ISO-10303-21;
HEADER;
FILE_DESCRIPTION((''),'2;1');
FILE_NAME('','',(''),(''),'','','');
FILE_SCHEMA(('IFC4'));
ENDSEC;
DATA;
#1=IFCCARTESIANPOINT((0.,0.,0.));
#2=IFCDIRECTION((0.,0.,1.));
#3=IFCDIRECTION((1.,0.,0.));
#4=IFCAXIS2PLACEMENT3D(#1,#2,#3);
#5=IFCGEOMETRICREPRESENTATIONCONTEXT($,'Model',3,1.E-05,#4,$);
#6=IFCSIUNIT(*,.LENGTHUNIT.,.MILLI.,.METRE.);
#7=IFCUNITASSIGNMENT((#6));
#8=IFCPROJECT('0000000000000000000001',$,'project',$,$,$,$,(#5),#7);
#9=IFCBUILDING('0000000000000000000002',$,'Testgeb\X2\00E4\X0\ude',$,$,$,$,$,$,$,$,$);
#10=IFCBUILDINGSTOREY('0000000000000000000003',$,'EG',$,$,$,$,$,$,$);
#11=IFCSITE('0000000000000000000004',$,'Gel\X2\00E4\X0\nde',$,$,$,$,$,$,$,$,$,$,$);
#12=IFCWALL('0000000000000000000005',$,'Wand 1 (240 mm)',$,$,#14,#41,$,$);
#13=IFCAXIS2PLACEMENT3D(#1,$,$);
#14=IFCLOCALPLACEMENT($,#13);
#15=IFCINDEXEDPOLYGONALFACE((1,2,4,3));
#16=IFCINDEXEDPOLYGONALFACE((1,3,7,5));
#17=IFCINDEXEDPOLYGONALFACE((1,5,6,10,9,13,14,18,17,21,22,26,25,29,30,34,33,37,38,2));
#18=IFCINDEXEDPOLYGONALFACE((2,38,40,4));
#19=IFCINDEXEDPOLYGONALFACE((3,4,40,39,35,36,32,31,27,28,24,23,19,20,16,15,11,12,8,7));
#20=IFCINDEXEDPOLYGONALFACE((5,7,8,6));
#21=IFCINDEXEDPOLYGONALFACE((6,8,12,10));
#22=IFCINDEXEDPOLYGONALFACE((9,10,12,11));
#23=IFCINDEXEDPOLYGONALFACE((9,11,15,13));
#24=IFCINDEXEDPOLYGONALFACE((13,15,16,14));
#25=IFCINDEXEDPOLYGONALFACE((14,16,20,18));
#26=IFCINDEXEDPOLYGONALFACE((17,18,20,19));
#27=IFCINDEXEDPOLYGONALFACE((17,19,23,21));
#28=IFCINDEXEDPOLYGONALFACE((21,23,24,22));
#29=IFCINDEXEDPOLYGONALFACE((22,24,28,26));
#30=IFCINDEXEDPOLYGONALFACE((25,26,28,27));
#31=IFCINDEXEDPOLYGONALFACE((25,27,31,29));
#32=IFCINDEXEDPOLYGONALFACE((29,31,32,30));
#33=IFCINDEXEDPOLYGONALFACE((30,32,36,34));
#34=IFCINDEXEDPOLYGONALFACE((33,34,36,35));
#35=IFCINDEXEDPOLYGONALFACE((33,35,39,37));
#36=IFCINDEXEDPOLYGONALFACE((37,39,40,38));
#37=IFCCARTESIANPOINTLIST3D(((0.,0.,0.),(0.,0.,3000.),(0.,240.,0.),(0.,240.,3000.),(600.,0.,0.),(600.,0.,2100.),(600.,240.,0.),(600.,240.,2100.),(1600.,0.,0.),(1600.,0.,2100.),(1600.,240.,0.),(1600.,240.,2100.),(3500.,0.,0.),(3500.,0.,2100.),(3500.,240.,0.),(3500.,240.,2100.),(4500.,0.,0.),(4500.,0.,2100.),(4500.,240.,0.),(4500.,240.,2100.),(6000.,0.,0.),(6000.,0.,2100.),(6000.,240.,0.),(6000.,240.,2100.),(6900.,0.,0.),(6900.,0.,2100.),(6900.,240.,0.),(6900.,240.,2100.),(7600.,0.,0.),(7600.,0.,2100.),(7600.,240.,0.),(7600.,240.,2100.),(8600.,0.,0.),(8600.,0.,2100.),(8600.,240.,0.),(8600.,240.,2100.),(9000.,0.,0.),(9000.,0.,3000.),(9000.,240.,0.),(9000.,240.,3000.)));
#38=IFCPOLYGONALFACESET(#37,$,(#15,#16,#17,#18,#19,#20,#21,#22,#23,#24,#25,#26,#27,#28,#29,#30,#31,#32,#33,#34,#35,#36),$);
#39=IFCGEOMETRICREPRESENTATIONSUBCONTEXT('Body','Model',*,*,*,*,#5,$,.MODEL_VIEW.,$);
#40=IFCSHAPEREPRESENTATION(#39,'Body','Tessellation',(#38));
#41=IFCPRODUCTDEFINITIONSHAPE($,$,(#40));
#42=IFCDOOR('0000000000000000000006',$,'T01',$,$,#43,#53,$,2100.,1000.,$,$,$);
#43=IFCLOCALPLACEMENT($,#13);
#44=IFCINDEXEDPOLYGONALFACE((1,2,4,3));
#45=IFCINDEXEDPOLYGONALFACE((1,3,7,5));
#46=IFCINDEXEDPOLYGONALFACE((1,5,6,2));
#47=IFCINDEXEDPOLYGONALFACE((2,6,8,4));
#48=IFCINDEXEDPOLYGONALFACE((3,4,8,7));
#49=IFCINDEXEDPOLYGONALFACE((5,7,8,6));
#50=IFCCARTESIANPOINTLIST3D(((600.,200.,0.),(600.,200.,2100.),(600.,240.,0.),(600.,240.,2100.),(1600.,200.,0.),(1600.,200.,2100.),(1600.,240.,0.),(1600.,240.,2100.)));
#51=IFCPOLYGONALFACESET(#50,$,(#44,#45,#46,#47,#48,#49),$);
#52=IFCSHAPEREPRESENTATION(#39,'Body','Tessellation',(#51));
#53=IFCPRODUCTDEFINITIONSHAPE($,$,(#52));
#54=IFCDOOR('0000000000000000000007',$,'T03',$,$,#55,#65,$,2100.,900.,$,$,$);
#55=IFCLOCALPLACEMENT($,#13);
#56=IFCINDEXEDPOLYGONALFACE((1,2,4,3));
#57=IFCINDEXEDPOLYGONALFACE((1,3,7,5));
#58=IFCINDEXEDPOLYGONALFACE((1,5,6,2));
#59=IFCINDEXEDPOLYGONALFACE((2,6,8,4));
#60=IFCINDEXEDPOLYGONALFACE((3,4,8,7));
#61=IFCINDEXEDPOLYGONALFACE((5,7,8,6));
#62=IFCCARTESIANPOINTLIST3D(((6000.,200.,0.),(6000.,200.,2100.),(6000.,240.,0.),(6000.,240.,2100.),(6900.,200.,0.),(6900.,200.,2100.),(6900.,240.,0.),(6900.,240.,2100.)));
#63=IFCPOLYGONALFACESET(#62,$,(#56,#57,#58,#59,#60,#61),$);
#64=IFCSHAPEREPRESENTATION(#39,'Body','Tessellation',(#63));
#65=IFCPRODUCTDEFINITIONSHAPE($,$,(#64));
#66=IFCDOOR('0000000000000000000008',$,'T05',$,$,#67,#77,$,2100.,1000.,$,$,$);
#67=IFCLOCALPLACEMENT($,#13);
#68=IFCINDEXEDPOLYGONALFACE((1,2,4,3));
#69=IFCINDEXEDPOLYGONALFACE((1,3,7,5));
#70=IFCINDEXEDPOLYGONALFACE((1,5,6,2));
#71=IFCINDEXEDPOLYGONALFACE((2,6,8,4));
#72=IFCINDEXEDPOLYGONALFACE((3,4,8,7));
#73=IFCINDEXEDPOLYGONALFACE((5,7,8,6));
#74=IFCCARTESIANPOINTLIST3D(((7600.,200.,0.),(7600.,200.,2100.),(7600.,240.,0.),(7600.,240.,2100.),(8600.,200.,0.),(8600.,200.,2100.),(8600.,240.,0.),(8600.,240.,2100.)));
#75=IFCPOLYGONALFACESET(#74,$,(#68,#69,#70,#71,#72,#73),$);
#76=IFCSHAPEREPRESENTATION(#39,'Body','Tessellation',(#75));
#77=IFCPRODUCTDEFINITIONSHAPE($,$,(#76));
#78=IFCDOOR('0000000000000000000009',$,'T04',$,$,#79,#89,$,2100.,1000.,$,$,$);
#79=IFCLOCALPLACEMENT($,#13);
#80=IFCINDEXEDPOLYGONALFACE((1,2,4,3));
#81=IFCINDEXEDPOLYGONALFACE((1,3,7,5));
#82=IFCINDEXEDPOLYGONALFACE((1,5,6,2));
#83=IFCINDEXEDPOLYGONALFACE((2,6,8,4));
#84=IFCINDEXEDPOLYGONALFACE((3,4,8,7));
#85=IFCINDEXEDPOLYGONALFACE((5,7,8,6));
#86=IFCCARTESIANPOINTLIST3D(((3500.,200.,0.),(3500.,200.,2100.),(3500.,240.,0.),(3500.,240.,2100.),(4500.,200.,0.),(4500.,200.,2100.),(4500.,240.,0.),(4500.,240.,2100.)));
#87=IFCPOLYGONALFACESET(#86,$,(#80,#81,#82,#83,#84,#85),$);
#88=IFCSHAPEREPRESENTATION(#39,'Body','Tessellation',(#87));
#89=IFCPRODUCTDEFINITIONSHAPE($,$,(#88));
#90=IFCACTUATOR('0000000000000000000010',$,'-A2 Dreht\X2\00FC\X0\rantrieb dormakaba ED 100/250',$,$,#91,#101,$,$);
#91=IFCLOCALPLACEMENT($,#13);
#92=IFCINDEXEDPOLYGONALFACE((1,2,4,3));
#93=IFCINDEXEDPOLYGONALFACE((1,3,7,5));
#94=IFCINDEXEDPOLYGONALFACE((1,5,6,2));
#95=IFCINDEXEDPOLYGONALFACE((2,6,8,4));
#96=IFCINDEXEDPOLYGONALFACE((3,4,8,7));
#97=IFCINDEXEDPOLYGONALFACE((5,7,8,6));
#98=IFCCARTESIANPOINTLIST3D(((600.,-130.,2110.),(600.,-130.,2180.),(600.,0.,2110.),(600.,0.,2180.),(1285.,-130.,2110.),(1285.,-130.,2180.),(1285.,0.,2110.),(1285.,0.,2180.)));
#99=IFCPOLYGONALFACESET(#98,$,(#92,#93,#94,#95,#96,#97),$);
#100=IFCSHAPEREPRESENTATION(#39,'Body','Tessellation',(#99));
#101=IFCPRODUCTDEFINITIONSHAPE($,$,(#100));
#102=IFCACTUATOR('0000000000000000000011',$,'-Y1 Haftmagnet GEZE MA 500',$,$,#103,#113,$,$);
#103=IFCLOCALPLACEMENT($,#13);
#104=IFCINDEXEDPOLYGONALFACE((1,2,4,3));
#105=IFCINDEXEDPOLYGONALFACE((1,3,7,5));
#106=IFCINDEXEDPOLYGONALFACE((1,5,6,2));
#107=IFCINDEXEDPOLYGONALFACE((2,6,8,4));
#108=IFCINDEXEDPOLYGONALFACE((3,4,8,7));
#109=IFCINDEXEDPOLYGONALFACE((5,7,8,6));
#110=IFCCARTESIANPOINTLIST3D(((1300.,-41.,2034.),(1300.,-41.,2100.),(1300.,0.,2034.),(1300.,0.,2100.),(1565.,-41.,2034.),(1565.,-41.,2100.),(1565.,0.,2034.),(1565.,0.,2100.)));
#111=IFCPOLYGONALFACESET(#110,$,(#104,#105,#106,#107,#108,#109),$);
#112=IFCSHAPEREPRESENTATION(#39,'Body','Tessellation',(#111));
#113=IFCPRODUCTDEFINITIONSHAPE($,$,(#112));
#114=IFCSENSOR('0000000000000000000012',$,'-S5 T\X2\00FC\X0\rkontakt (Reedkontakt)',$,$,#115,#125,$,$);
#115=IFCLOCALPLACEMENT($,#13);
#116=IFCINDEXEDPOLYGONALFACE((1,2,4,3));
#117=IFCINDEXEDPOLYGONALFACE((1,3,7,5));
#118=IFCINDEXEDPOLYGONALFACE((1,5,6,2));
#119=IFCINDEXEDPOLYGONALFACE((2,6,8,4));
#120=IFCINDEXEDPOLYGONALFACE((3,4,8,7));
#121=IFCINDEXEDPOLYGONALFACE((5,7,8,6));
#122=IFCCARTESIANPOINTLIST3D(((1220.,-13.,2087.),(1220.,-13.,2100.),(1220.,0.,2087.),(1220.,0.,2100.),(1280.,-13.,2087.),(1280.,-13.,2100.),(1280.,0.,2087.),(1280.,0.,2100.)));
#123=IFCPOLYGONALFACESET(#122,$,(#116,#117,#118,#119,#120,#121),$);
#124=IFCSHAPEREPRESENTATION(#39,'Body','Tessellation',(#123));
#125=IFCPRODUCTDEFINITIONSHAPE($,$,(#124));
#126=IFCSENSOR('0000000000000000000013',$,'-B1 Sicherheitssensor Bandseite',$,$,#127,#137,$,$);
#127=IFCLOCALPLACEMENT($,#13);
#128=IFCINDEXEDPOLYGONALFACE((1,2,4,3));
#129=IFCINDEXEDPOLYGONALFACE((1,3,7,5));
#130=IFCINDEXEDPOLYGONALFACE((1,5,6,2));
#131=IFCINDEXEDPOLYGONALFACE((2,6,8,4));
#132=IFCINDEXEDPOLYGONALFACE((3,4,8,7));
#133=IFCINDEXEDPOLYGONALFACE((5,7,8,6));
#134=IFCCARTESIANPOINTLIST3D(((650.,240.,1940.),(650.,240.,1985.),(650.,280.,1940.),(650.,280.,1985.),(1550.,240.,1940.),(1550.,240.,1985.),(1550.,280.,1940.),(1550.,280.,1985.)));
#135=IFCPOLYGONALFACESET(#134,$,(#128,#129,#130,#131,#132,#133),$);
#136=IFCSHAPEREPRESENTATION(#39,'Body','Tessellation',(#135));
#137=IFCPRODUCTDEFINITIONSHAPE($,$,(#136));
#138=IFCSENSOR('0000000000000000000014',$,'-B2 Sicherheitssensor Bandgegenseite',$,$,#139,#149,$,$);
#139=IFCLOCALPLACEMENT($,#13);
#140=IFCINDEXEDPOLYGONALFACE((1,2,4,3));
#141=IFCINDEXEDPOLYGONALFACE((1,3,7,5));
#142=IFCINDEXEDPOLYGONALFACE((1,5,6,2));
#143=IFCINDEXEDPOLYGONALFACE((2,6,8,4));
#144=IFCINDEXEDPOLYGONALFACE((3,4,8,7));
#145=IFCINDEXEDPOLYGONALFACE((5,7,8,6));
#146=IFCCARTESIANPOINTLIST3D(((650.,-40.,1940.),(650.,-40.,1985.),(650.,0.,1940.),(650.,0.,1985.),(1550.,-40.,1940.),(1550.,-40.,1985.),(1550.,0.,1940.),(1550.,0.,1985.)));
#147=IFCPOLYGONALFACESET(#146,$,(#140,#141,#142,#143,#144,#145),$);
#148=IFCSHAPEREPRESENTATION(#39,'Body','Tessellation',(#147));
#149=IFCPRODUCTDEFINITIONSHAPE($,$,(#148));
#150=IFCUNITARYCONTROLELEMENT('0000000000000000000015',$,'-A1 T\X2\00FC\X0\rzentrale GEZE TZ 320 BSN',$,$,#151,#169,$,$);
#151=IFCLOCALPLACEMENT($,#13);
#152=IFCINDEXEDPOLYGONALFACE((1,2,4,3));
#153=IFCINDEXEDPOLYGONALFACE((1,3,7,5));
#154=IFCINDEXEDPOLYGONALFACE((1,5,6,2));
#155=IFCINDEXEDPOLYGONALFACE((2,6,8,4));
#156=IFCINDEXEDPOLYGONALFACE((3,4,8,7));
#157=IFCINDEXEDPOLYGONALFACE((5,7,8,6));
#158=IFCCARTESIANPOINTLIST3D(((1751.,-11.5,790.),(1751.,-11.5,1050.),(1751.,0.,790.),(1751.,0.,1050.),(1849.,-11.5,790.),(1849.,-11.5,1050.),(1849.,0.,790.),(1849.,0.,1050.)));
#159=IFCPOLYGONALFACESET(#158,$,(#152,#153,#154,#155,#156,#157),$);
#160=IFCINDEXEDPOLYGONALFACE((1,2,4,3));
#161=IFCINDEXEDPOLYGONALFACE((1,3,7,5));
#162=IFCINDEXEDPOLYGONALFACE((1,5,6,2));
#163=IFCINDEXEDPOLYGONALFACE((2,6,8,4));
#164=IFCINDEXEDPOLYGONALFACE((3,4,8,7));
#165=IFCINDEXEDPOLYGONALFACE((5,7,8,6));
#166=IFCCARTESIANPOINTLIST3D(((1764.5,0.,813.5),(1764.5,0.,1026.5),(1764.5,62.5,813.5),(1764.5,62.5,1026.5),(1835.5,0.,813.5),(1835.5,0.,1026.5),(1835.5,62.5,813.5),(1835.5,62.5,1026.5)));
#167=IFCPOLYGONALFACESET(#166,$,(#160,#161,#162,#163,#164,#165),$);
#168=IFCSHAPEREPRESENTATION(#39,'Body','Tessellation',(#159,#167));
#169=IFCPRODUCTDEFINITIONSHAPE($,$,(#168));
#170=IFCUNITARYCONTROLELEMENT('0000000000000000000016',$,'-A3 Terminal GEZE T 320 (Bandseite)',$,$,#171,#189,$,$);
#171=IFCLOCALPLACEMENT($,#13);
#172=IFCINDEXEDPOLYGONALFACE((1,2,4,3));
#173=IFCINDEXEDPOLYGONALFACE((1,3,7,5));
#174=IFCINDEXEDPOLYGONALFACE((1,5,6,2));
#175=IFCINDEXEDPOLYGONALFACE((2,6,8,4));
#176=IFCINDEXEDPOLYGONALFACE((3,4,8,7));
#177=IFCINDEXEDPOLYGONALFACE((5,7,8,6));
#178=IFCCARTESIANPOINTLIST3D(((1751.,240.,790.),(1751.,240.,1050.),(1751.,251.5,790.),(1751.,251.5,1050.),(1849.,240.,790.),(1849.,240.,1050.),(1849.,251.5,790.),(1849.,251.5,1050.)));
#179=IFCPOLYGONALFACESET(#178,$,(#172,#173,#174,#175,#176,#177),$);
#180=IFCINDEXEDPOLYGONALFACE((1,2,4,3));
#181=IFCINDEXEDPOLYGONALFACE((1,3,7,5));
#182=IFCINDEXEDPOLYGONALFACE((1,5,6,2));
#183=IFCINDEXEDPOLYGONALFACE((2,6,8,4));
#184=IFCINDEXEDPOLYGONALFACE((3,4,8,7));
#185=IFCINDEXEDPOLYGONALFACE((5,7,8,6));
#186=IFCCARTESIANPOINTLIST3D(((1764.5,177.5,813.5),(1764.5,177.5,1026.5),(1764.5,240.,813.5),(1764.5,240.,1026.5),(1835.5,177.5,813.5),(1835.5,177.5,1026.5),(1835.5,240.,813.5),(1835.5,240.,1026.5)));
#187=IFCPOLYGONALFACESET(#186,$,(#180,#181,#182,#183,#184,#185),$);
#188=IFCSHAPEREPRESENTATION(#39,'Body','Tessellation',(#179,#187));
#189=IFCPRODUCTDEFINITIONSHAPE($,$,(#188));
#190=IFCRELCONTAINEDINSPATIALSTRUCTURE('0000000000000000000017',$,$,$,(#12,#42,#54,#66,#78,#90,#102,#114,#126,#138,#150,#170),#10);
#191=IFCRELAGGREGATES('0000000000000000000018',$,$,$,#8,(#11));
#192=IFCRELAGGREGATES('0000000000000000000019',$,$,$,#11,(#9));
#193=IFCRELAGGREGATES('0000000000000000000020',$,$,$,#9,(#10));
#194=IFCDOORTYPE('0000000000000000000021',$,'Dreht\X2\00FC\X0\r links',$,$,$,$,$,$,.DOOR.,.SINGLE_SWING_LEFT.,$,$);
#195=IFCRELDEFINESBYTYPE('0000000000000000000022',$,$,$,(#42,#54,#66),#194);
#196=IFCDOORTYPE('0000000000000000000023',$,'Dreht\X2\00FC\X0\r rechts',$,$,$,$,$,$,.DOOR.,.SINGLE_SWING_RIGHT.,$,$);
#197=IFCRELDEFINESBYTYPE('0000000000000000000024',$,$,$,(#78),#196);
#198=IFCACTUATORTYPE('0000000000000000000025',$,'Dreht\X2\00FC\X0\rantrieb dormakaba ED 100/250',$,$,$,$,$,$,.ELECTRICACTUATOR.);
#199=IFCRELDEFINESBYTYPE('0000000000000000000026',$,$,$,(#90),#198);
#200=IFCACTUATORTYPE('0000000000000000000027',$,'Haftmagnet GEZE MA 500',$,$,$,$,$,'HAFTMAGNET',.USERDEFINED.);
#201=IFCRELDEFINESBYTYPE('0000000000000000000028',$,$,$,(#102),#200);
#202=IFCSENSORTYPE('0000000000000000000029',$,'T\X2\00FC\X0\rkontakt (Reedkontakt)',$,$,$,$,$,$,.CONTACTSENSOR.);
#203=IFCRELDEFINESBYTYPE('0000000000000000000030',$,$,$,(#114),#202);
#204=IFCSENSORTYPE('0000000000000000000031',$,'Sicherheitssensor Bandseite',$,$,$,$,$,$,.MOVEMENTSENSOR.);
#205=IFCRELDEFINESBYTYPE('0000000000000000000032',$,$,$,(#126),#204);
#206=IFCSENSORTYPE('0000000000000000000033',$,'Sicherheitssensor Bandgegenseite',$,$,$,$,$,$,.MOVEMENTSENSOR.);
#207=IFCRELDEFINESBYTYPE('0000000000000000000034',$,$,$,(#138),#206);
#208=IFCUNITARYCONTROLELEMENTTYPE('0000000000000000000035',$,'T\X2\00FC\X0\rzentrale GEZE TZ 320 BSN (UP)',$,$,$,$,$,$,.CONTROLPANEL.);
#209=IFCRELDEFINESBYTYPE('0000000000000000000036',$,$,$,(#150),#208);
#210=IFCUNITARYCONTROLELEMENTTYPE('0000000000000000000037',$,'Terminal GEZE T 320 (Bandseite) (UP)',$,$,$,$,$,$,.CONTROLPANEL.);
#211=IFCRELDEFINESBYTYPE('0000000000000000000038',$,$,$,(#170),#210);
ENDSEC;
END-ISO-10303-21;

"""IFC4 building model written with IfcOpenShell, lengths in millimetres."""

from ifc_helpers import new_model, si_unit, frame, frame_2d, origin_with_axes, place, context, subcontext, project, spatial, rectangle, extrude, type_object, element, fill, save


model = new_model("IFC4")

# Units and contexts
model_context = context("Model", 3, precision=1e-05, world=origin_with_axes())
body_context = subcontext(model_context, "Body", "Model", "MODEL_VIEW")
ifc_project = project(units=[si_unit("LENGTHUNIT", "METRE", prefix="MILLI")], contexts=[model_context])

# Site, building, storey
site = spatial("IfcSite", under=ifc_project, Name="Gelände")
building = spatial("IfcBuilding", under=site, Name="Testgebäude")
storey = spatial("IfcBuildingStorey", under=building, Name="EG")

# Wall, openings, doors
wall_placement = place(None, origin_with_axes())
wall = element("IfcWall", 1, at=wall_placement, inside=storey, Name="Wand 1 (240 mm)", context=body_context, shape_type="SweptSolid", body=[
    extrude(rectangle(XDim=9000.0, YDim=240.0, at=frame_2d((4500.0, 120.0))), None, (0.0, 0.0, 1.0), 3000.0),
])
opening_1_placement = place(None, frame((600.0, 0.0, 0.0), z_axis=(0.0, 0.0, 1.0), x_axis=(1.0, 0.0, 0.0)))
opening_1 = element("IfcOpeningElement", 2, at=opening_1_placement, cuts=wall, context=body_context, shape_type="SweptSolid", body=[
    extrude(rectangle(XDim=1000.0, YDim=240.0, at=frame_2d((500.0, 120.0))), None, (0.0, 0.0, 1.0), 2100.0),
])
opening_2_placement = place(None, frame((3500.0, 0.0, 0.0), z_axis=(0.0, 0.0, 1.0), x_axis=(1.0, 0.0, 0.0)))
opening_2 = element("IfcOpeningElement", 3, at=opening_2_placement, cuts=wall, context=body_context, shape_type="SweptSolid", body=[
    extrude(rectangle(XDim=1000.0, YDim=240.0, at=frame_2d((500.0, 120.0))), None, (0.0, 0.0, 1.0), 2100.0),
])
opening_3_placement = place(None, frame((6000.0, 0.0, 0.0), z_axis=(0.0, 0.0, 1.0), x_axis=(1.0, 0.0, 0.0)))
opening_3 = element("IfcOpeningElement", 4, at=opening_3_placement, cuts=wall, context=body_context, shape_type="SweptSolid", body=[
    extrude(rectangle(XDim=900.0, YDim=240.0, at=frame_2d((450.0, 120.0))), None, (0.0, 0.0, 1.0), 2100.0),
])
opening_4_placement = place(None, frame((7600.0, 0.0, 0.0), z_axis=(0.0, 0.0, 1.0), x_axis=(1.0, 0.0, 0.0)))
opening_4 = element("IfcOpeningElement", 5, at=opening_4_placement, cuts=wall, context=body_context, shape_type="SweptSolid", body=[
    extrude(rectangle(XDim=1000.0, YDim=240.0, at=frame_2d((500.0, 120.0))), None, (0.0, 0.0, 1.0), 2100.0),
])
door_type_1 = type_object("IfcDoorType", Name="Drehtür links", OperationType="SINGLE_SWING_LEFT", PredefinedType="DOOR")
door_1_placement = place(opening_1_placement, origin_with_axes())
door_1 = element("IfcDoor", 6, at=door_1_placement, inside=storey, type_object=door_type_1, Name="T01", OverallHeight=2100.0, OverallWidth=1000.0, context=body_context, shape_type="SweptSolid", body=[
    extrude(rectangle(XDim=1000.0, YDim=40.0, at=frame_2d((500.0, 20.0))), frame((0.0, 200.0, 0.0)), (0.0, 0.0, 1.0), 2100.0),
])
fill(opening_1, door_1)
door_2_placement = place(opening_3_placement, origin_with_axes())
door_2 = element("IfcDoor", 7, at=door_2_placement, inside=storey, type_object=door_type_1, Name="T03", OverallHeight=2100.0, OverallWidth=900.0, context=body_context, shape_type="SweptSolid", body=[
    extrude(rectangle(XDim=900.0, YDim=40.0, at=frame_2d((450.0, 20.0))), frame((0.0, 200.0, 0.0)), (0.0, 0.0, 1.0), 2100.0),
])
fill(opening_3, door_2)
door_3_placement = place(opening_4_placement, origin_with_axes())
door_3 = element("IfcDoor", 8, at=door_3_placement, inside=storey, type_object=door_type_1, Name="T05", OverallHeight=2100.0, OverallWidth=1000.0, context=body_context, shape_type="SweptSolid", body=[
    extrude(rectangle(XDim=1000.0, YDim=40.0, at=frame_2d((500.0, 20.0))), frame((0.0, 200.0, 0.0)), (0.0, 0.0, 1.0), 2100.0),
])
fill(opening_4, door_3)
door_type_2 = type_object("IfcDoorType", Name="Drehtür rechts", OperationType="SINGLE_SWING_RIGHT", PredefinedType="DOOR")
door_4_placement = place(opening_2_placement, origin_with_axes())
door_4 = element("IfcDoor", 9, at=door_4_placement, inside=storey, type_object=door_type_2, Name="T04", OverallHeight=2100.0, OverallWidth=1000.0, context=body_context, shape_type="SweptSolid", body=[
    extrude(rectangle(XDim=1000.0, YDim=40.0, at=frame_2d((500.0, 20.0))), frame((0.0, 200.0, 0.0)), (0.0, 0.0, 1.0), 2100.0),
])
fill(opening_2, door_4)

# Actuators
actuator_type_1 = type_object("IfcActuatorType", Name="Drehtürantrieb dormakaba ED 100/250", PredefinedType="ELECTRICACTUATOR")
actuator_1_placement = place(None, frame((600.0, -130.0, 2110.0), z_axis=(0.0, 0.0, 1.0), x_axis=(1.0, 0.0, 0.0)))
element("IfcActuator", 10, at=actuator_1_placement, inside=storey, type_object=actuator_type_1, Name="-A2 Drehtürantrieb dormakaba ED 100/250", context=body_context, shape_type="SweptSolid", body=[
    extrude(rectangle(XDim=685.0, YDim=130.0, at=frame_2d((342.5, 65.0))), None, (0.0, 0.0, 1.0), 70.0),
])
actuator_type_2 = type_object("IfcActuatorType", Name="Haftmagnet GEZE MA 500", ElementType="HAFTMAGNET", PredefinedType="USERDEFINED")
actuator_2_placement = place(None, frame((1300.0, -41.0, 2034.0), z_axis=(0.0, 0.0, 1.0), x_axis=(1.0, 0.0, 0.0)))
element("IfcActuator", 11, at=actuator_2_placement, inside=storey, type_object=actuator_type_2, Name="-Y1 Haftmagnet GEZE MA 500", context=body_context, shape_type="SweptSolid", body=[
    extrude(rectangle(XDim=265.0, YDim=41.0, at=frame_2d((132.5, 20.5))), None, (0.0, 0.0, 1.0), 66.0),
])

# Sensors
sensor_type_1 = type_object("IfcSensorType", Name="Türkontakt (Reedkontakt)", PredefinedType="CONTACTSENSOR")
sensor_1_placement = place(None, frame((1220.0, -13.0, 2087.0), z_axis=(0.0, 0.0, 1.0), x_axis=(1.0, 0.0, 0.0)))
element("IfcSensor", 12, at=sensor_1_placement, inside=storey, type_object=sensor_type_1, Name="-S5 Türkontakt (Reedkontakt)", context=body_context, shape_type="SweptSolid", body=[
    extrude(rectangle(XDim=60.0, YDim=13.0, at=frame_2d((30.0, 6.5))), None, (0.0, 0.0, 1.0), 13.0),
])
sensor_type_2 = type_object("IfcSensorType", Name="Sicherheitssensor Bandseite", PredefinedType="MOVEMENTSENSOR")
sensor_2_placement = place(None, frame((650.0, 240.0, 1940.0), z_axis=(0.0, 0.0, 1.0), x_axis=(1.0, 0.0, 0.0)))
element("IfcSensor", 13, at=sensor_2_placement, inside=storey, type_object=sensor_type_2, Name="-B1 Sicherheitssensor Bandseite", context=body_context, shape_type="SweptSolid", body=[
    extrude(rectangle(XDim=900.0, YDim=40.0, at=frame_2d((450.0, 20.0))), None, (0.0, 0.0, 1.0), 45.0),
])
sensor_type_3 = type_object("IfcSensorType", Name="Sicherheitssensor Bandgegenseite", PredefinedType="MOVEMENTSENSOR")
sensor_3_placement = place(None, frame((650.0, -40.0, 1940.0), z_axis=(0.0, 0.0, 1.0), x_axis=(1.0, 0.0, 0.0)))
element("IfcSensor", 14, at=sensor_3_placement, inside=storey, type_object=sensor_type_3, Name="-B2 Sicherheitssensor Bandgegenseite", context=body_context, shape_type="SweptSolid", body=[
    extrude(rectangle(XDim=900.0, YDim=40.0, at=frame_2d((450.0, 20.0))), None, (0.0, 0.0, 1.0), 45.0),
])

# Unitary control elements
unitary_control_element_type_1 = type_object("IfcUnitaryControlElementType", Name="Türzentrale GEZE TZ 320 BSN (UP)", PredefinedType="CONTROLPANEL")
unitary_control_element_1_placement = place(None, frame((1751.0, -11.5, 790.0), z_axis=(0.0, 0.0, 1.0), x_axis=(1.0, 0.0, 0.0)))
element("IfcUnitaryControlElement", 15, at=unitary_control_element_1_placement, inside=storey, type_object=unitary_control_element_type_1, Name="-A1 Türzentrale GEZE TZ 320 BSN", context=body_context, shape_type="SweptSolid", body=[
    extrude(rectangle(XDim=98.0, YDim=11.5, at=frame_2d((49.0, 5.8))), None, (0.0, 0.0, 1.0), 260.0),
    extrude(rectangle(XDim=71.0, YDim=62.5, at=frame_2d((35.5, 31.2))), frame((13.5, 11.5, 23.5), z_axis=(0.0, 0.0, 1.0), x_axis=(1.0, 0.0, 0.0)), (0.0, 0.0, 1.0), 213.0),
])
unitary_control_element_type_2 = type_object("IfcUnitaryControlElementType", Name="Terminal GEZE T 320 (Bandseite) (UP)", PredefinedType="CONTROLPANEL")
unitary_control_element_2_placement = place(None, frame((1751.0, 240.0, 790.0), z_axis=(0.0, 0.0, 1.0), x_axis=(1.0, 0.0, 0.0)))
element("IfcUnitaryControlElement", 16, at=unitary_control_element_2_placement, inside=storey, type_object=unitary_control_element_type_2, Name="-A3 Terminal GEZE T 320 (Bandseite)", context=body_context, shape_type="SweptSolid", body=[
    extrude(rectangle(XDim=98.0, YDim=11.5, at=frame_2d((49.0, 5.8))), None, (0.0, 0.0, 1.0), 260.0),
    extrude(rectangle(XDim=71.0, YDim=62.5, at=frame_2d((35.5, 31.2))), frame((13.5, -62.5, 23.5), z_axis=(0.0, 0.0, 1.0), x_axis=(1.0, 0.0, 0.0)), (0.0, 0.0, 1.0), 213.0),
])

save(model, "model.ifc")
